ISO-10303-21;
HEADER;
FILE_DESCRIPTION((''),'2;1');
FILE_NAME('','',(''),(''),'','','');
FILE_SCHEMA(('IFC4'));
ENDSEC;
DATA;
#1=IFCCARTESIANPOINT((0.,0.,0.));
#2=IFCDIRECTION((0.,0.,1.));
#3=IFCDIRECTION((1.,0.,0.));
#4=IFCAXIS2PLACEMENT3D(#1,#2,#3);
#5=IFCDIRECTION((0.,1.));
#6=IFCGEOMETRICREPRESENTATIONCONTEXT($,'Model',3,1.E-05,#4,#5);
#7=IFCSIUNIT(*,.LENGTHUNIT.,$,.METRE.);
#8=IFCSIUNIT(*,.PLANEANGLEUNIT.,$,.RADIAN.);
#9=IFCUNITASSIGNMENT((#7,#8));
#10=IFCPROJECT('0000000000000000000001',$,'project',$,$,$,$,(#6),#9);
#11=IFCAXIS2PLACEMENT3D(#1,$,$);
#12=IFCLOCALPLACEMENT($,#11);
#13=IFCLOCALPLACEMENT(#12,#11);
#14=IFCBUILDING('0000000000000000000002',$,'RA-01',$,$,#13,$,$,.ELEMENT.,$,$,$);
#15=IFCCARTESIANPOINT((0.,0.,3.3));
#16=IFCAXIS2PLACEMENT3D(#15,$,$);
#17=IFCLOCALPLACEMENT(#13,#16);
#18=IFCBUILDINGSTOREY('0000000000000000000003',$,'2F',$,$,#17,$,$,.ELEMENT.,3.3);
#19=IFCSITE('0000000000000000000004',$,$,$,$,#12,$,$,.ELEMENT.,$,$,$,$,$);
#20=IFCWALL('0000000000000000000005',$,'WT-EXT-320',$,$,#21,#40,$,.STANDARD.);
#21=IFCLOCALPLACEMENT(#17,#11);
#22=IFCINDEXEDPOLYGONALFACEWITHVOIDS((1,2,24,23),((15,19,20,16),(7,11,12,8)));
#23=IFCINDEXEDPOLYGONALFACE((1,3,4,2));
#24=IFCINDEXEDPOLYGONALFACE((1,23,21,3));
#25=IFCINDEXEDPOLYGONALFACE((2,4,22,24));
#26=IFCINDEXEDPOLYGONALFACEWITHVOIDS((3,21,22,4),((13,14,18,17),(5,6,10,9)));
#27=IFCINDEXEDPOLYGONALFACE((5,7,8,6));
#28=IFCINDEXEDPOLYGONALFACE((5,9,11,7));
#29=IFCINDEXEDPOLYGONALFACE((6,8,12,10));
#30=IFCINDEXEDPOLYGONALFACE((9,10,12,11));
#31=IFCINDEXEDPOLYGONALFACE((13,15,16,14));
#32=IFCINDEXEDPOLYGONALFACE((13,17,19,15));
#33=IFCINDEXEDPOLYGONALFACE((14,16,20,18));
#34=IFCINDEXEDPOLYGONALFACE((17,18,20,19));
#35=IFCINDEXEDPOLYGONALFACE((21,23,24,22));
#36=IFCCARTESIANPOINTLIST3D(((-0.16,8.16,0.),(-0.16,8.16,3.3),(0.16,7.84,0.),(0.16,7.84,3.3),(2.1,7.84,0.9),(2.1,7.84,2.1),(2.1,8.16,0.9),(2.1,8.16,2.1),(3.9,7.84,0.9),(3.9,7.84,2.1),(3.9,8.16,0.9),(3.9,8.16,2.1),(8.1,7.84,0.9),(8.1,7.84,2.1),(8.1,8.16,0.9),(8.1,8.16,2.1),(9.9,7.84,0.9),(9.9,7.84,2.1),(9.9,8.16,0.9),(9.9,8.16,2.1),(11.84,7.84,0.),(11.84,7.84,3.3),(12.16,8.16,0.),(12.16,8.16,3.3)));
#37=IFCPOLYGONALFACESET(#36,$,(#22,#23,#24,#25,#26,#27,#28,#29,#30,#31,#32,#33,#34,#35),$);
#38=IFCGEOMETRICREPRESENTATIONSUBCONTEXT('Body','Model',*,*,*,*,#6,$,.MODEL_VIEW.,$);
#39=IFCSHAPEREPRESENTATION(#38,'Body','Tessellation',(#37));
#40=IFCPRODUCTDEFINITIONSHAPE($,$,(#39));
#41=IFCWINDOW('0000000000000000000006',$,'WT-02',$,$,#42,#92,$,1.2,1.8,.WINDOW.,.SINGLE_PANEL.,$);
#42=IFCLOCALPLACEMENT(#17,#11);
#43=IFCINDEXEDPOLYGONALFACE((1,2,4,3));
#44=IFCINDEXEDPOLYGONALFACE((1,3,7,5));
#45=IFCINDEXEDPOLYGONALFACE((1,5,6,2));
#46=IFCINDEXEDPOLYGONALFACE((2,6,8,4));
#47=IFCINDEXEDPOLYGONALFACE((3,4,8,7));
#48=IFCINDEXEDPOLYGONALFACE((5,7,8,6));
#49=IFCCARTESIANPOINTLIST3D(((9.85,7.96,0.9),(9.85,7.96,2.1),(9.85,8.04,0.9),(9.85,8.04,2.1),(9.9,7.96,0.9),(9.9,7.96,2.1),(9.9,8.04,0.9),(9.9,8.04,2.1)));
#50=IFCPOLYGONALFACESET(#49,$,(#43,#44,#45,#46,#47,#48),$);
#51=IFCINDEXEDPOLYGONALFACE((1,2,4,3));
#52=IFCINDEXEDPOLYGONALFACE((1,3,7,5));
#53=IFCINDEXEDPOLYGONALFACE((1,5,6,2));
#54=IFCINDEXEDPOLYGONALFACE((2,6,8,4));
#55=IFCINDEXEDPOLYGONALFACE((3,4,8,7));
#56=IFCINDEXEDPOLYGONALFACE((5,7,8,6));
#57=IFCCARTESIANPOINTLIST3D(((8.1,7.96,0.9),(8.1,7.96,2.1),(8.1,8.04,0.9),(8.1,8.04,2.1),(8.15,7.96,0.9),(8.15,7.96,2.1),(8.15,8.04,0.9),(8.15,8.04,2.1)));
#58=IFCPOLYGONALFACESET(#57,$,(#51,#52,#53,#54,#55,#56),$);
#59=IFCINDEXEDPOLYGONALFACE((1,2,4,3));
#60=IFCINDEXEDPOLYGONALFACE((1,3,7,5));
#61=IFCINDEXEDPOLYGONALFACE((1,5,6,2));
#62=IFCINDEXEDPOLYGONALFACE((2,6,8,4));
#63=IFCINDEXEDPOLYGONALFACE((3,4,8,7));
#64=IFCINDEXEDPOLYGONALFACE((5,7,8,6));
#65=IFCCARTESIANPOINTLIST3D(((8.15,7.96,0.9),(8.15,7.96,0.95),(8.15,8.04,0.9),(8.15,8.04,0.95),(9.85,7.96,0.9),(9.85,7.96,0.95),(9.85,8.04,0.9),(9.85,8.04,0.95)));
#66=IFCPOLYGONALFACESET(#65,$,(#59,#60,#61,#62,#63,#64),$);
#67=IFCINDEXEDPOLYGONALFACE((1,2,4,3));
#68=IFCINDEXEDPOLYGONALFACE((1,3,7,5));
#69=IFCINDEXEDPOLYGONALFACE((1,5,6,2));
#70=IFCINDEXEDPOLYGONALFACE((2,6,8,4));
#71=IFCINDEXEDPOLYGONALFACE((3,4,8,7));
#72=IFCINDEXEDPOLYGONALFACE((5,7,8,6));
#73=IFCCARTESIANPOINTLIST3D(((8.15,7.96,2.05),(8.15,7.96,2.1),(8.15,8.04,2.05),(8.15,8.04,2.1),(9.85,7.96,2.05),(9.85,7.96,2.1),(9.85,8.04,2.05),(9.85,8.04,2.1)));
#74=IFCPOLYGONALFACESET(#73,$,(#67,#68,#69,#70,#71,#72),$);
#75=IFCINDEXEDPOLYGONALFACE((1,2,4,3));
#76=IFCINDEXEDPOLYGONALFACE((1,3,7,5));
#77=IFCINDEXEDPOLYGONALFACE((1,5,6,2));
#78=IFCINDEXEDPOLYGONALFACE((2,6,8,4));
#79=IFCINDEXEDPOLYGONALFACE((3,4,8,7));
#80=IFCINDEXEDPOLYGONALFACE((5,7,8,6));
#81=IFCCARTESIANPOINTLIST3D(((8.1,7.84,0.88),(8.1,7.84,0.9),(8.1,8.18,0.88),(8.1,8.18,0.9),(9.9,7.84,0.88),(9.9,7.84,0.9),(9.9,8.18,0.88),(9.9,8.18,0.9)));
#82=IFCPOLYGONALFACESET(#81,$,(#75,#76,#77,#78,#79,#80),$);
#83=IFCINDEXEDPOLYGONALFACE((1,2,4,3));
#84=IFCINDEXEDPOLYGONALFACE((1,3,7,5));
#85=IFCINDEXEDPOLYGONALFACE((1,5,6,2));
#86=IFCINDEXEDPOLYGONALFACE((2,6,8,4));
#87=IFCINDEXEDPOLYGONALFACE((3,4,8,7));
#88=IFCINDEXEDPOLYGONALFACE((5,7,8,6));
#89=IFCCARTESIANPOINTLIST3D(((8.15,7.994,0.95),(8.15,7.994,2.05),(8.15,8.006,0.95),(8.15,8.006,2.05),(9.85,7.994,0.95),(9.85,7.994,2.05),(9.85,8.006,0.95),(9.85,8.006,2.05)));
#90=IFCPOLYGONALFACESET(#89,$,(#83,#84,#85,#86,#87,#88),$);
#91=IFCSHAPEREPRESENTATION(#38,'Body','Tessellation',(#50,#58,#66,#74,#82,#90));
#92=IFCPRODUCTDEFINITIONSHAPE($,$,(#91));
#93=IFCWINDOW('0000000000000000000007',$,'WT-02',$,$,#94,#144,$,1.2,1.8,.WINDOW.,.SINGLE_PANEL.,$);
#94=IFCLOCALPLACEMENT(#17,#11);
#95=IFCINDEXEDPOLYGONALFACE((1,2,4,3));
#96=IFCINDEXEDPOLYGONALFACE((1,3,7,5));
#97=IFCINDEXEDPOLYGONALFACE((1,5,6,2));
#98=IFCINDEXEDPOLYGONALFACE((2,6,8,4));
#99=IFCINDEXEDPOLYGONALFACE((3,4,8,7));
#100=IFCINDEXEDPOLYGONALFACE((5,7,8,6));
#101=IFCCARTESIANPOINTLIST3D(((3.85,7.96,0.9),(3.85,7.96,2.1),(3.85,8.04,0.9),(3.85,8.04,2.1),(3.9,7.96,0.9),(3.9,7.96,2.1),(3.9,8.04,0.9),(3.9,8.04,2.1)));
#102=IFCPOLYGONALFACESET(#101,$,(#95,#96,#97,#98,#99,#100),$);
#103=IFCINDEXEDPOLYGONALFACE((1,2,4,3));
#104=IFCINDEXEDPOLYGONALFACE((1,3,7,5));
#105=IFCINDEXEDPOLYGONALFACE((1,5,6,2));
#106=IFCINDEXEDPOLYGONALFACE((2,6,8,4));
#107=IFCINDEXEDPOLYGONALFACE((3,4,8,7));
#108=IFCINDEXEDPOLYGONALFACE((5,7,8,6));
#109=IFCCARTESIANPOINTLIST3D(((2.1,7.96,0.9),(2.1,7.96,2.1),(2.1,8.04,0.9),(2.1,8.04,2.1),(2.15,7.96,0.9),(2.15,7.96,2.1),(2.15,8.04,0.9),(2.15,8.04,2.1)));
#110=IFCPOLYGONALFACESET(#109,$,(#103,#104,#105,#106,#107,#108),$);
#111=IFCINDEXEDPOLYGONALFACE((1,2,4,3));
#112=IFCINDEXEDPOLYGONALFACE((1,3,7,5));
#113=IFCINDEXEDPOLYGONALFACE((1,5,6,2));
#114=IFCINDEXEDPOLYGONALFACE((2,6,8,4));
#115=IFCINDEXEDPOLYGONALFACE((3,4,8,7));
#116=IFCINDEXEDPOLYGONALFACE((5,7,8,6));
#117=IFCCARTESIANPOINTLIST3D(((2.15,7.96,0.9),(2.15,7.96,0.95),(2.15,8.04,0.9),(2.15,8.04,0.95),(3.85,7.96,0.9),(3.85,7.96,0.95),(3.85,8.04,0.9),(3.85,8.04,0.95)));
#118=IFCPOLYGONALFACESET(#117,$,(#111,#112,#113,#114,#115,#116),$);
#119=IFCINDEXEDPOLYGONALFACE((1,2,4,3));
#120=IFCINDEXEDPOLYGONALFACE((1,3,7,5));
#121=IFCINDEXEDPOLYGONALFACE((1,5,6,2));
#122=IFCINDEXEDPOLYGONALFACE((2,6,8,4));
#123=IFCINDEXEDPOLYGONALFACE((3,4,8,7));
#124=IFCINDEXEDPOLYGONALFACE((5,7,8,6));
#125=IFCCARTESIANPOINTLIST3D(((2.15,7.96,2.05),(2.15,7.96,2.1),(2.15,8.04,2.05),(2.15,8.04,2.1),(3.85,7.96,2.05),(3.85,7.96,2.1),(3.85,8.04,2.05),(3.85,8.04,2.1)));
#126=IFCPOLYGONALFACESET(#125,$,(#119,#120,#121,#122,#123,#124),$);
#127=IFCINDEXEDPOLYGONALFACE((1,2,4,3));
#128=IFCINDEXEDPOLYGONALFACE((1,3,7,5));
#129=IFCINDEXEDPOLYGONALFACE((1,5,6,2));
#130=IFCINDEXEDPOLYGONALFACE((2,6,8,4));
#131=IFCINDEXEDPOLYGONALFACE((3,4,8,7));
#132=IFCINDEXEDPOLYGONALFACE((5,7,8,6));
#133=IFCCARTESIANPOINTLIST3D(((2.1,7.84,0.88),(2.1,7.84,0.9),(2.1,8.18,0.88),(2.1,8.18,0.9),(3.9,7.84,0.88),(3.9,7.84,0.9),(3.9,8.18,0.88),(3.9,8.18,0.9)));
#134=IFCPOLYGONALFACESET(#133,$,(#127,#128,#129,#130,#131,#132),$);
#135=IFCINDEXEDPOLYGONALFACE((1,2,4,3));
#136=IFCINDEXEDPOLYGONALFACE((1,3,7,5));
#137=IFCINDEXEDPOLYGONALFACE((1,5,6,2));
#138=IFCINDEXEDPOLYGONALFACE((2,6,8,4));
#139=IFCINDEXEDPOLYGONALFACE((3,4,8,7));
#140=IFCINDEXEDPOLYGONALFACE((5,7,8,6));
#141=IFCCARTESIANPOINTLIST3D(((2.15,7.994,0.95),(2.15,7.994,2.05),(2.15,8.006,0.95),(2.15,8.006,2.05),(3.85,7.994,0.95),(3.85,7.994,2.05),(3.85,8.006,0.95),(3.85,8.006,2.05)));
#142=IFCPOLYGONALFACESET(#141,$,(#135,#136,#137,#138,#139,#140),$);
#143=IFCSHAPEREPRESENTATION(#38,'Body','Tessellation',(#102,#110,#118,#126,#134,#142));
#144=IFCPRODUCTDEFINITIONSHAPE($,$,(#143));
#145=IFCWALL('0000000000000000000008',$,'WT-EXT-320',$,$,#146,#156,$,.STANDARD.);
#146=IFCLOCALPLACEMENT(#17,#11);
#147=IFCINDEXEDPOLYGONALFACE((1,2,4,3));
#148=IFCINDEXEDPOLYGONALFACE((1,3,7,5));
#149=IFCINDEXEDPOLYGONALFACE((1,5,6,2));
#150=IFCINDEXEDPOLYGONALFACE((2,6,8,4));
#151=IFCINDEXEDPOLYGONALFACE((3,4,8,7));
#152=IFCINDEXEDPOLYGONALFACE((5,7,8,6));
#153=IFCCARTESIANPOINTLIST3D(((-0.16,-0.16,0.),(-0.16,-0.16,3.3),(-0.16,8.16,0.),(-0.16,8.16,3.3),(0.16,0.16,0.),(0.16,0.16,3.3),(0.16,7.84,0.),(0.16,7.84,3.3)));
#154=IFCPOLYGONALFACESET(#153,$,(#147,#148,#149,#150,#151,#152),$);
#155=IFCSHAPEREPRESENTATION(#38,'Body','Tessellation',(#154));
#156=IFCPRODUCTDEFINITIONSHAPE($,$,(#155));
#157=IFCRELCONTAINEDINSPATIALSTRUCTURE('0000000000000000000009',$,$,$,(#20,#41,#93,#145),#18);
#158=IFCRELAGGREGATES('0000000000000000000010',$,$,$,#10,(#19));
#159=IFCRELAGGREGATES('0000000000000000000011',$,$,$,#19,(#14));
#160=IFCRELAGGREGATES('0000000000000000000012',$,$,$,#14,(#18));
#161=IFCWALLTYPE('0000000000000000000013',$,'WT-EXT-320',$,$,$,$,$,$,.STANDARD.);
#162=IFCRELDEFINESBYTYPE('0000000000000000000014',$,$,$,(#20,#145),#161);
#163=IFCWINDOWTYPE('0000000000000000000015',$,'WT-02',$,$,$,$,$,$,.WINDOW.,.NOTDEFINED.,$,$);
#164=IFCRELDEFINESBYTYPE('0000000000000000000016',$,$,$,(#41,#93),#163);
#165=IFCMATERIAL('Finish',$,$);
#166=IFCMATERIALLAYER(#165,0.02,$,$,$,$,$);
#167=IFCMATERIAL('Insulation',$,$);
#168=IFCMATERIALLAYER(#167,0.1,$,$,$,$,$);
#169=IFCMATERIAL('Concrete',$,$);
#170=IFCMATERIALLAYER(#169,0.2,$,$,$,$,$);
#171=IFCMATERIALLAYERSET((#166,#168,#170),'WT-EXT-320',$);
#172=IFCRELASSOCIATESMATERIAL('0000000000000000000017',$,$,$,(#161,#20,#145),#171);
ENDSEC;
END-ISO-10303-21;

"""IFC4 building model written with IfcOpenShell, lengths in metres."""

from ifc_helpers import new_model, si_unit, direction, frame, frame_2d, origin, origin_with_axes, place, context, subcontext, project, spatial, polyline, rectangle, outline, extrude, material, layer, layer_set, layer_usage, type_object, element, fill, save


model = new_model("IFC4")

# Units and contexts
model_context = context("Model", 3, precision=1e-05, world=origin_with_axes(), true_north=direction((0.0, 1.0)))
body_context = subcontext(model_context, "Body", "Model", "MODEL_VIEW")
ifc_project = project(units=[si_unit("LENGTHUNIT", "METRE"), si_unit("PLANEANGLEUNIT", "RADIAN")], contexts=[model_context])

# Site, building, storey
site_placement = place(None, origin())
site = spatial("IfcSite", under=ifc_project, at=site_placement, CompositionType="ELEMENT")
building_placement = place(site_placement, origin())
building = spatial("IfcBuilding", under=site, at=building_placement, Name="RA-01", CompositionType="ELEMENT")
storey_placement = place(building_placement, frame((0.0, 0.0, 3.3)))
storey = spatial("IfcBuildingStorey", under=building, at=storey_placement, Name="2F", CompositionType="ELEMENT", Elevation=3.3)

# Shared definitions
ifc_material_1 = material(Name="Concrete")

# Shared definitions
ifc_material_2 = material(Name="Finish")
ifc_layer_1 = layer(ifc_material_2, 0.02)
ifc_material_3 = material(Name="Insulation")
ifc_layer_2 = layer(ifc_material_3, 0.1)
ifc_layer_3 = layer(ifc_material_1, 0.2)
ifc_layer_set_1 = layer_set([ifc_layer_1, ifc_layer_2, ifc_layer_3], Name="WT-EXT-320")
ifc_layer_usage_1 = layer_usage(ifc_layer_set_1, "AXIS2", "NEGATIVE", 0.16)
wall_type_1 = type_object("IfcWallType", Name="WT-EXT-320", PredefinedType="STANDARD", material=ifc_layer_set_1)

# Wall, openings, windows
wall_1_placement = place(storey_placement, frame((12.0, 8.0, 0.0), z_axis=(0.0, 0.0, 1.0), x_axis=(-1.0, 0.0, 0.0)))
wall_1 = element("IfcWall", 1, at=wall_1_placement, inside=storey, type_object=wall_type_1, material=ifc_layer_usage_1, Name="WT-EXT-320", PredefinedType="STANDARD", context=body_context, shape_type="SweptSolid", body=[
    extrude(outline(polyline([(-0.16, -0.16), (12.16, -0.16), (11.84, 0.16), (0.16, 0.16), (-0.16, -0.16)])), origin(), (0.0, 0.0, 1.0), 3.3),
])
opening_1_placement = place(wall_1_placement, frame((2.1, 0.0, 0.9)))
opening_1 = element("IfcOpeningElement", 2, at=opening_1_placement, cuts=wall_1, PredefinedType="OPENING", context=body_context, shape_type="SweptSolid", body=[
    extrude(rectangle(XDim=1.8, YDim=0.42, at=frame_2d((0.9, 0.0))), origin(), (0.0, 0.0, 1.0), 1.2),
])
opening_2_placement = place(wall_1_placement, frame((8.1, 0.0, 0.9)))
opening_2 = element("IfcOpeningElement", 3, at=opening_2_placement, cuts=wall_1, PredefinedType="OPENING", context=body_context, shape_type="SweptSolid", body=[
    extrude(rectangle(XDim=1.8, YDim=0.42, at=frame_2d((0.9, 0.0))), origin(), (0.0, 0.0, 1.0), 1.2),
])
window_type_1 = type_object("IfcWindowType", Name="WT-02", PartitioningType="NOTDEFINED", PredefinedType="WINDOW")
window_1_placement = place(opening_1_placement, origin())
window_1 = element("IfcWindow", 4, at=window_1_placement, inside=storey, type_object=window_type_1, Name="WT-02", OverallHeight=1.2, OverallWidth=1.8, PartitioningType="SINGLE_PANEL", PredefinedType="WINDOW", context=body_context, shape_type="SweptSolid", body=[
    extrude(outline(polyline([(0.0, -0.04), (0.05, -0.04), (0.05, 0.04), (0.0, 0.04), (0.0, -0.04)])), origin(), (0.0, 0.0, 1.0), 1.2),
    extrude(outline(polyline([(1.75, -0.04), (1.8, -0.04), (1.8, 0.04), (1.75, 0.04), (1.75, -0.04)])), origin(), (0.0, 0.0, 1.0), 1.2),
    extrude(outline(polyline([(0.05, -0.04), (1.75, -0.04), (1.75, 0.04), (0.05, 0.04), (0.05, -0.04)])), origin(), (0.0, 0.0, 1.0), 0.05),
    extrude(outline(polyline([(0.05, -0.04), (1.75, -0.04), (1.75, 0.04), (0.05, 0.04), (0.05, -0.04)])), frame((0.0, 0.0, 1.15)), (0.0, 0.0, 1.0), 0.05),
    extrude(outline(polyline([(0.0, -0.18), (1.8, -0.18), (1.8, 0.16), (0.0, 0.16), (0.0, -0.18)])), frame((0.0, 0.0, -0.02)), (0.0, 0.0, 1.0), 0.02),
    extrude(outline(polyline([(0.05, -0.006), (1.75, -0.006), (1.75, 0.006), (0.05, 0.006), (0.05, -0.006)])), frame((0.0, 0.0, 0.05)), (0.0, 0.0, 1.0), 1.1),
])
fill(opening_1, window_1)
window_2_placement = place(opening_2_placement, origin())
window_2 = element("IfcWindow", 5, at=window_2_placement, inside=storey, type_object=window_type_1, Name="WT-02", OverallHeight=1.2, OverallWidth=1.8, PartitioningType="SINGLE_PANEL", PredefinedType="WINDOW", context=body_context, shape_type="SweptSolid", body=[
    extrude(outline(polyline([(0.0, -0.04), (0.05, -0.04), (0.05, 0.04), (0.0, 0.04), (0.0, -0.04)])), origin(), (0.0, 0.0, 1.0), 1.2),
    extrude(outline(polyline([(1.75, -0.04), (1.8, -0.04), (1.8, 0.04), (1.75, 0.04), (1.75, -0.04)])), origin(), (0.0, 0.0, 1.0), 1.2),
    extrude(outline(polyline([(0.05, -0.04), (1.75, -0.04), (1.75, 0.04), (0.05, 0.04), (0.05, -0.04)])), origin(), (0.0, 0.0, 1.0), 0.05),
    extrude(outline(polyline([(0.05, -0.04), (1.75, -0.04), (1.75, 0.04), (0.05, 0.04), (0.05, -0.04)])), frame((0.0, 0.0, 1.15)), (0.0, 0.0, 1.0), 0.05),
    extrude(outline(polyline([(0.0, -0.18), (1.8, -0.18), (1.8, 0.16), (0.0, 0.16), (0.0, -0.18)])), frame((0.0, 0.0, -0.02)), (0.0, 0.0, 1.0), 0.02),
    extrude(outline(polyline([(0.05, -0.006), (1.75, -0.006), (1.75, 0.006), (0.05, 0.006), (0.05, -0.006)])), frame((0.0, 0.0, 0.05)), (0.0, 0.0, 1.0), 1.1),
])
fill(opening_2, window_2)

# Wall
wall_2_placement = place(storey_placement, frame((0.0, 8.0, 0.0), z_axis=(0.0, 0.0, 1.0), x_axis=(0.0, -1.0, 0.0)))
element("IfcWall", 6, at=wall_2_placement, inside=storey, type_object=wall_type_1, material=ifc_layer_usage_1, Name="WT-EXT-320", PredefinedType="STANDARD", context=body_context, shape_type="SweptSolid", body=[
    extrude(outline(polyline([(-0.16, -0.16), (8.16, -0.16), (7.84, 0.16), (0.16, 0.16), (-0.16, -0.16)])), origin(), (0.0, 0.0, 1.0), 3.3),
])

save(model, "model.ifc")
